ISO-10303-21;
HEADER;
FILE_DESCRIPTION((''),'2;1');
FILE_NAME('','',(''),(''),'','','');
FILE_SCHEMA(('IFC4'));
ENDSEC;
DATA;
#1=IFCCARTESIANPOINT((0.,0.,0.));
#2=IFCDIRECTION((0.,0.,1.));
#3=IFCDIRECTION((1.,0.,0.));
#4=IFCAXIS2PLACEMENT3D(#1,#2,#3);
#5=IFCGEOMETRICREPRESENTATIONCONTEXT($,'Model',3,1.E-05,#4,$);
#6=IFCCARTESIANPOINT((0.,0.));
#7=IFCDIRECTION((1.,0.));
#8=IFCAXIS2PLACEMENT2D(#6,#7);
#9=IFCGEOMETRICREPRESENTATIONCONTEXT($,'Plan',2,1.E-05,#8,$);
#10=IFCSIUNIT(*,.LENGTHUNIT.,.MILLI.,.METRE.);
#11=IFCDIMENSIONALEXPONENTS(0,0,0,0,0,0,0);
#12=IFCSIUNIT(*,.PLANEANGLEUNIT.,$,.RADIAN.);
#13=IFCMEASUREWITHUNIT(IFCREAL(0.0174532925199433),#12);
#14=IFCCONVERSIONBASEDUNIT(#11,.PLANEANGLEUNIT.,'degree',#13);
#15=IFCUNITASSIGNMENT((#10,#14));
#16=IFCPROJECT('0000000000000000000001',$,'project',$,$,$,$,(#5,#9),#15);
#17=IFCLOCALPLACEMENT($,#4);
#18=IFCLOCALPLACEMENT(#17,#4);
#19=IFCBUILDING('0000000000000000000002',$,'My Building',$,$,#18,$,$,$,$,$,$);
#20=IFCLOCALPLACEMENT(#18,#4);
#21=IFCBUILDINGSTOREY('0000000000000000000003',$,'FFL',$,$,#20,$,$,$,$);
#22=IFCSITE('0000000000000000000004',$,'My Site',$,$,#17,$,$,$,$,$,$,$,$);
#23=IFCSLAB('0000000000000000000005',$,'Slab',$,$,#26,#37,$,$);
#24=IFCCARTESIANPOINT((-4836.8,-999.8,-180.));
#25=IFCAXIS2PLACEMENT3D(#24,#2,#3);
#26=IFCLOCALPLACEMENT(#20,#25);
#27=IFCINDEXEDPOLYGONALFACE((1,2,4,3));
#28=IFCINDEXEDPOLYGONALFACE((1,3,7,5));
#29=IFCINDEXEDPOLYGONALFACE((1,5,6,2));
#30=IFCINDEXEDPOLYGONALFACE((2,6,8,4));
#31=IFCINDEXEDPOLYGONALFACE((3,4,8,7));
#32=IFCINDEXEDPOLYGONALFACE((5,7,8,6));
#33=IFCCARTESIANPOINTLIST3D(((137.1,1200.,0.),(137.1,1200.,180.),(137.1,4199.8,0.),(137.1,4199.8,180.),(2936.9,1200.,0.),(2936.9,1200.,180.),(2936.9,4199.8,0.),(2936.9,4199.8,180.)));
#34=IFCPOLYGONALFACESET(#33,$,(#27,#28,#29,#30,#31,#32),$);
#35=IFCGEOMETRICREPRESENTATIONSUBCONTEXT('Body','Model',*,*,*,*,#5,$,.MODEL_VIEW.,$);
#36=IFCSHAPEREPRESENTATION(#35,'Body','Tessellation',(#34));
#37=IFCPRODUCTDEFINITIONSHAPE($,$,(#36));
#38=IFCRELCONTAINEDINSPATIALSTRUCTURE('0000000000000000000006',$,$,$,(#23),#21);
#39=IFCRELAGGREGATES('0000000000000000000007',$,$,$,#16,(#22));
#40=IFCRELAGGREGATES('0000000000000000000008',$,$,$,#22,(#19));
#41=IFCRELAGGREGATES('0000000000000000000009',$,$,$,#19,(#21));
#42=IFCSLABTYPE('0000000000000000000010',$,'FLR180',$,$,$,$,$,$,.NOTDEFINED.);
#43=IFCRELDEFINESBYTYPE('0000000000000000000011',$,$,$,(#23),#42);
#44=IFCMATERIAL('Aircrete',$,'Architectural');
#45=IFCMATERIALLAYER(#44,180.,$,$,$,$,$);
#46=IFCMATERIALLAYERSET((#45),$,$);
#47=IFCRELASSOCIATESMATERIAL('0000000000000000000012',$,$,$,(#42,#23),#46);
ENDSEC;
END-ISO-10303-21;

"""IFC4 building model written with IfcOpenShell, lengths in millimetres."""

from ifc_helpers import new_model, entity, si_unit, converted_unit, frame, origin_with_axes, origin_2d_with_axis, place, context, subcontext, project, spatial, indexed_curve, outline, extrude, material, layer, layer_set, layer_usage, type_object, element, save


model = new_model("IFC4")

# Units and contexts
model_context = context("Model", 3, precision=1e-05, world=origin_with_axes())
plan_context = context("Plan", 2, precision=1e-05, world=origin_2d_with_axis())
body_context_1 = subcontext(model_context, "Body", "Model", "MODEL_VIEW")
ifc_project = project(units=[si_unit("LENGTHUNIT", "METRE", prefix="MILLI"), converted_unit("PLANEANGLEUNIT", "degree", entity("IfcReal", 0.0174532925199433), si_unit("PLANEANGLEUNIT", "RADIAN"), dimensions=[0, 0, 0, 0, 0, 0, 0])], contexts=[model_context, plan_context])

# Site, building, storey
site_placement = place(None, origin_with_axes())
site = spatial("IfcSite", under=ifc_project, at=site_placement, Name="My Site")
building_placement = place(site_placement, origin_with_axes())
building = spatial("IfcBuilding", under=site, at=building_placement, Name="My Building")
storey_placement = place(building_placement, origin_with_axes())
storey = spatial("IfcBuildingStorey", under=building, at=storey_placement, Name="FFL")

# Shared definitions
ifc_material_1 = material(Name="Aircrete", Category="Architectural")
ifc_layer_1 = layer(ifc_material_1, 180.0)
ifc_layer_set_1 = layer_set([ifc_layer_1])
slab_type = type_object("IfcSlabType", Name="FLR180", PredefinedType="NOTDEFINED", material=ifc_layer_set_1)

# Slab
ifc_layer_usage_1 = layer_usage(ifc_layer_set_1, "AXIS3", "POSITIVE", 0.0)
slab_1_placement = place(storey_placement, frame((-4836.8, -999.8, -180.0), z_axis=(0.0, 0.0, 1.0), x_axis=(1.0, 0.0, 0.0)))
element("IfcSlab", 1, at=slab_1_placement, inside=storey, type_object=slab_type, material=ifc_layer_usage_1, Name="Slab", context=body_context_1, shape_type="SweptSolid", body=[
    extrude(outline(indexed_curve([(137.1, 4199.8), (2936.9, 4199.8), (2936.9, 1200.0), (137.1, 1200.0), (137.1, 4199.8)])), None, (0.0, 0.0, 1.0), 180.0),
])

save(model, "model.ifc")
